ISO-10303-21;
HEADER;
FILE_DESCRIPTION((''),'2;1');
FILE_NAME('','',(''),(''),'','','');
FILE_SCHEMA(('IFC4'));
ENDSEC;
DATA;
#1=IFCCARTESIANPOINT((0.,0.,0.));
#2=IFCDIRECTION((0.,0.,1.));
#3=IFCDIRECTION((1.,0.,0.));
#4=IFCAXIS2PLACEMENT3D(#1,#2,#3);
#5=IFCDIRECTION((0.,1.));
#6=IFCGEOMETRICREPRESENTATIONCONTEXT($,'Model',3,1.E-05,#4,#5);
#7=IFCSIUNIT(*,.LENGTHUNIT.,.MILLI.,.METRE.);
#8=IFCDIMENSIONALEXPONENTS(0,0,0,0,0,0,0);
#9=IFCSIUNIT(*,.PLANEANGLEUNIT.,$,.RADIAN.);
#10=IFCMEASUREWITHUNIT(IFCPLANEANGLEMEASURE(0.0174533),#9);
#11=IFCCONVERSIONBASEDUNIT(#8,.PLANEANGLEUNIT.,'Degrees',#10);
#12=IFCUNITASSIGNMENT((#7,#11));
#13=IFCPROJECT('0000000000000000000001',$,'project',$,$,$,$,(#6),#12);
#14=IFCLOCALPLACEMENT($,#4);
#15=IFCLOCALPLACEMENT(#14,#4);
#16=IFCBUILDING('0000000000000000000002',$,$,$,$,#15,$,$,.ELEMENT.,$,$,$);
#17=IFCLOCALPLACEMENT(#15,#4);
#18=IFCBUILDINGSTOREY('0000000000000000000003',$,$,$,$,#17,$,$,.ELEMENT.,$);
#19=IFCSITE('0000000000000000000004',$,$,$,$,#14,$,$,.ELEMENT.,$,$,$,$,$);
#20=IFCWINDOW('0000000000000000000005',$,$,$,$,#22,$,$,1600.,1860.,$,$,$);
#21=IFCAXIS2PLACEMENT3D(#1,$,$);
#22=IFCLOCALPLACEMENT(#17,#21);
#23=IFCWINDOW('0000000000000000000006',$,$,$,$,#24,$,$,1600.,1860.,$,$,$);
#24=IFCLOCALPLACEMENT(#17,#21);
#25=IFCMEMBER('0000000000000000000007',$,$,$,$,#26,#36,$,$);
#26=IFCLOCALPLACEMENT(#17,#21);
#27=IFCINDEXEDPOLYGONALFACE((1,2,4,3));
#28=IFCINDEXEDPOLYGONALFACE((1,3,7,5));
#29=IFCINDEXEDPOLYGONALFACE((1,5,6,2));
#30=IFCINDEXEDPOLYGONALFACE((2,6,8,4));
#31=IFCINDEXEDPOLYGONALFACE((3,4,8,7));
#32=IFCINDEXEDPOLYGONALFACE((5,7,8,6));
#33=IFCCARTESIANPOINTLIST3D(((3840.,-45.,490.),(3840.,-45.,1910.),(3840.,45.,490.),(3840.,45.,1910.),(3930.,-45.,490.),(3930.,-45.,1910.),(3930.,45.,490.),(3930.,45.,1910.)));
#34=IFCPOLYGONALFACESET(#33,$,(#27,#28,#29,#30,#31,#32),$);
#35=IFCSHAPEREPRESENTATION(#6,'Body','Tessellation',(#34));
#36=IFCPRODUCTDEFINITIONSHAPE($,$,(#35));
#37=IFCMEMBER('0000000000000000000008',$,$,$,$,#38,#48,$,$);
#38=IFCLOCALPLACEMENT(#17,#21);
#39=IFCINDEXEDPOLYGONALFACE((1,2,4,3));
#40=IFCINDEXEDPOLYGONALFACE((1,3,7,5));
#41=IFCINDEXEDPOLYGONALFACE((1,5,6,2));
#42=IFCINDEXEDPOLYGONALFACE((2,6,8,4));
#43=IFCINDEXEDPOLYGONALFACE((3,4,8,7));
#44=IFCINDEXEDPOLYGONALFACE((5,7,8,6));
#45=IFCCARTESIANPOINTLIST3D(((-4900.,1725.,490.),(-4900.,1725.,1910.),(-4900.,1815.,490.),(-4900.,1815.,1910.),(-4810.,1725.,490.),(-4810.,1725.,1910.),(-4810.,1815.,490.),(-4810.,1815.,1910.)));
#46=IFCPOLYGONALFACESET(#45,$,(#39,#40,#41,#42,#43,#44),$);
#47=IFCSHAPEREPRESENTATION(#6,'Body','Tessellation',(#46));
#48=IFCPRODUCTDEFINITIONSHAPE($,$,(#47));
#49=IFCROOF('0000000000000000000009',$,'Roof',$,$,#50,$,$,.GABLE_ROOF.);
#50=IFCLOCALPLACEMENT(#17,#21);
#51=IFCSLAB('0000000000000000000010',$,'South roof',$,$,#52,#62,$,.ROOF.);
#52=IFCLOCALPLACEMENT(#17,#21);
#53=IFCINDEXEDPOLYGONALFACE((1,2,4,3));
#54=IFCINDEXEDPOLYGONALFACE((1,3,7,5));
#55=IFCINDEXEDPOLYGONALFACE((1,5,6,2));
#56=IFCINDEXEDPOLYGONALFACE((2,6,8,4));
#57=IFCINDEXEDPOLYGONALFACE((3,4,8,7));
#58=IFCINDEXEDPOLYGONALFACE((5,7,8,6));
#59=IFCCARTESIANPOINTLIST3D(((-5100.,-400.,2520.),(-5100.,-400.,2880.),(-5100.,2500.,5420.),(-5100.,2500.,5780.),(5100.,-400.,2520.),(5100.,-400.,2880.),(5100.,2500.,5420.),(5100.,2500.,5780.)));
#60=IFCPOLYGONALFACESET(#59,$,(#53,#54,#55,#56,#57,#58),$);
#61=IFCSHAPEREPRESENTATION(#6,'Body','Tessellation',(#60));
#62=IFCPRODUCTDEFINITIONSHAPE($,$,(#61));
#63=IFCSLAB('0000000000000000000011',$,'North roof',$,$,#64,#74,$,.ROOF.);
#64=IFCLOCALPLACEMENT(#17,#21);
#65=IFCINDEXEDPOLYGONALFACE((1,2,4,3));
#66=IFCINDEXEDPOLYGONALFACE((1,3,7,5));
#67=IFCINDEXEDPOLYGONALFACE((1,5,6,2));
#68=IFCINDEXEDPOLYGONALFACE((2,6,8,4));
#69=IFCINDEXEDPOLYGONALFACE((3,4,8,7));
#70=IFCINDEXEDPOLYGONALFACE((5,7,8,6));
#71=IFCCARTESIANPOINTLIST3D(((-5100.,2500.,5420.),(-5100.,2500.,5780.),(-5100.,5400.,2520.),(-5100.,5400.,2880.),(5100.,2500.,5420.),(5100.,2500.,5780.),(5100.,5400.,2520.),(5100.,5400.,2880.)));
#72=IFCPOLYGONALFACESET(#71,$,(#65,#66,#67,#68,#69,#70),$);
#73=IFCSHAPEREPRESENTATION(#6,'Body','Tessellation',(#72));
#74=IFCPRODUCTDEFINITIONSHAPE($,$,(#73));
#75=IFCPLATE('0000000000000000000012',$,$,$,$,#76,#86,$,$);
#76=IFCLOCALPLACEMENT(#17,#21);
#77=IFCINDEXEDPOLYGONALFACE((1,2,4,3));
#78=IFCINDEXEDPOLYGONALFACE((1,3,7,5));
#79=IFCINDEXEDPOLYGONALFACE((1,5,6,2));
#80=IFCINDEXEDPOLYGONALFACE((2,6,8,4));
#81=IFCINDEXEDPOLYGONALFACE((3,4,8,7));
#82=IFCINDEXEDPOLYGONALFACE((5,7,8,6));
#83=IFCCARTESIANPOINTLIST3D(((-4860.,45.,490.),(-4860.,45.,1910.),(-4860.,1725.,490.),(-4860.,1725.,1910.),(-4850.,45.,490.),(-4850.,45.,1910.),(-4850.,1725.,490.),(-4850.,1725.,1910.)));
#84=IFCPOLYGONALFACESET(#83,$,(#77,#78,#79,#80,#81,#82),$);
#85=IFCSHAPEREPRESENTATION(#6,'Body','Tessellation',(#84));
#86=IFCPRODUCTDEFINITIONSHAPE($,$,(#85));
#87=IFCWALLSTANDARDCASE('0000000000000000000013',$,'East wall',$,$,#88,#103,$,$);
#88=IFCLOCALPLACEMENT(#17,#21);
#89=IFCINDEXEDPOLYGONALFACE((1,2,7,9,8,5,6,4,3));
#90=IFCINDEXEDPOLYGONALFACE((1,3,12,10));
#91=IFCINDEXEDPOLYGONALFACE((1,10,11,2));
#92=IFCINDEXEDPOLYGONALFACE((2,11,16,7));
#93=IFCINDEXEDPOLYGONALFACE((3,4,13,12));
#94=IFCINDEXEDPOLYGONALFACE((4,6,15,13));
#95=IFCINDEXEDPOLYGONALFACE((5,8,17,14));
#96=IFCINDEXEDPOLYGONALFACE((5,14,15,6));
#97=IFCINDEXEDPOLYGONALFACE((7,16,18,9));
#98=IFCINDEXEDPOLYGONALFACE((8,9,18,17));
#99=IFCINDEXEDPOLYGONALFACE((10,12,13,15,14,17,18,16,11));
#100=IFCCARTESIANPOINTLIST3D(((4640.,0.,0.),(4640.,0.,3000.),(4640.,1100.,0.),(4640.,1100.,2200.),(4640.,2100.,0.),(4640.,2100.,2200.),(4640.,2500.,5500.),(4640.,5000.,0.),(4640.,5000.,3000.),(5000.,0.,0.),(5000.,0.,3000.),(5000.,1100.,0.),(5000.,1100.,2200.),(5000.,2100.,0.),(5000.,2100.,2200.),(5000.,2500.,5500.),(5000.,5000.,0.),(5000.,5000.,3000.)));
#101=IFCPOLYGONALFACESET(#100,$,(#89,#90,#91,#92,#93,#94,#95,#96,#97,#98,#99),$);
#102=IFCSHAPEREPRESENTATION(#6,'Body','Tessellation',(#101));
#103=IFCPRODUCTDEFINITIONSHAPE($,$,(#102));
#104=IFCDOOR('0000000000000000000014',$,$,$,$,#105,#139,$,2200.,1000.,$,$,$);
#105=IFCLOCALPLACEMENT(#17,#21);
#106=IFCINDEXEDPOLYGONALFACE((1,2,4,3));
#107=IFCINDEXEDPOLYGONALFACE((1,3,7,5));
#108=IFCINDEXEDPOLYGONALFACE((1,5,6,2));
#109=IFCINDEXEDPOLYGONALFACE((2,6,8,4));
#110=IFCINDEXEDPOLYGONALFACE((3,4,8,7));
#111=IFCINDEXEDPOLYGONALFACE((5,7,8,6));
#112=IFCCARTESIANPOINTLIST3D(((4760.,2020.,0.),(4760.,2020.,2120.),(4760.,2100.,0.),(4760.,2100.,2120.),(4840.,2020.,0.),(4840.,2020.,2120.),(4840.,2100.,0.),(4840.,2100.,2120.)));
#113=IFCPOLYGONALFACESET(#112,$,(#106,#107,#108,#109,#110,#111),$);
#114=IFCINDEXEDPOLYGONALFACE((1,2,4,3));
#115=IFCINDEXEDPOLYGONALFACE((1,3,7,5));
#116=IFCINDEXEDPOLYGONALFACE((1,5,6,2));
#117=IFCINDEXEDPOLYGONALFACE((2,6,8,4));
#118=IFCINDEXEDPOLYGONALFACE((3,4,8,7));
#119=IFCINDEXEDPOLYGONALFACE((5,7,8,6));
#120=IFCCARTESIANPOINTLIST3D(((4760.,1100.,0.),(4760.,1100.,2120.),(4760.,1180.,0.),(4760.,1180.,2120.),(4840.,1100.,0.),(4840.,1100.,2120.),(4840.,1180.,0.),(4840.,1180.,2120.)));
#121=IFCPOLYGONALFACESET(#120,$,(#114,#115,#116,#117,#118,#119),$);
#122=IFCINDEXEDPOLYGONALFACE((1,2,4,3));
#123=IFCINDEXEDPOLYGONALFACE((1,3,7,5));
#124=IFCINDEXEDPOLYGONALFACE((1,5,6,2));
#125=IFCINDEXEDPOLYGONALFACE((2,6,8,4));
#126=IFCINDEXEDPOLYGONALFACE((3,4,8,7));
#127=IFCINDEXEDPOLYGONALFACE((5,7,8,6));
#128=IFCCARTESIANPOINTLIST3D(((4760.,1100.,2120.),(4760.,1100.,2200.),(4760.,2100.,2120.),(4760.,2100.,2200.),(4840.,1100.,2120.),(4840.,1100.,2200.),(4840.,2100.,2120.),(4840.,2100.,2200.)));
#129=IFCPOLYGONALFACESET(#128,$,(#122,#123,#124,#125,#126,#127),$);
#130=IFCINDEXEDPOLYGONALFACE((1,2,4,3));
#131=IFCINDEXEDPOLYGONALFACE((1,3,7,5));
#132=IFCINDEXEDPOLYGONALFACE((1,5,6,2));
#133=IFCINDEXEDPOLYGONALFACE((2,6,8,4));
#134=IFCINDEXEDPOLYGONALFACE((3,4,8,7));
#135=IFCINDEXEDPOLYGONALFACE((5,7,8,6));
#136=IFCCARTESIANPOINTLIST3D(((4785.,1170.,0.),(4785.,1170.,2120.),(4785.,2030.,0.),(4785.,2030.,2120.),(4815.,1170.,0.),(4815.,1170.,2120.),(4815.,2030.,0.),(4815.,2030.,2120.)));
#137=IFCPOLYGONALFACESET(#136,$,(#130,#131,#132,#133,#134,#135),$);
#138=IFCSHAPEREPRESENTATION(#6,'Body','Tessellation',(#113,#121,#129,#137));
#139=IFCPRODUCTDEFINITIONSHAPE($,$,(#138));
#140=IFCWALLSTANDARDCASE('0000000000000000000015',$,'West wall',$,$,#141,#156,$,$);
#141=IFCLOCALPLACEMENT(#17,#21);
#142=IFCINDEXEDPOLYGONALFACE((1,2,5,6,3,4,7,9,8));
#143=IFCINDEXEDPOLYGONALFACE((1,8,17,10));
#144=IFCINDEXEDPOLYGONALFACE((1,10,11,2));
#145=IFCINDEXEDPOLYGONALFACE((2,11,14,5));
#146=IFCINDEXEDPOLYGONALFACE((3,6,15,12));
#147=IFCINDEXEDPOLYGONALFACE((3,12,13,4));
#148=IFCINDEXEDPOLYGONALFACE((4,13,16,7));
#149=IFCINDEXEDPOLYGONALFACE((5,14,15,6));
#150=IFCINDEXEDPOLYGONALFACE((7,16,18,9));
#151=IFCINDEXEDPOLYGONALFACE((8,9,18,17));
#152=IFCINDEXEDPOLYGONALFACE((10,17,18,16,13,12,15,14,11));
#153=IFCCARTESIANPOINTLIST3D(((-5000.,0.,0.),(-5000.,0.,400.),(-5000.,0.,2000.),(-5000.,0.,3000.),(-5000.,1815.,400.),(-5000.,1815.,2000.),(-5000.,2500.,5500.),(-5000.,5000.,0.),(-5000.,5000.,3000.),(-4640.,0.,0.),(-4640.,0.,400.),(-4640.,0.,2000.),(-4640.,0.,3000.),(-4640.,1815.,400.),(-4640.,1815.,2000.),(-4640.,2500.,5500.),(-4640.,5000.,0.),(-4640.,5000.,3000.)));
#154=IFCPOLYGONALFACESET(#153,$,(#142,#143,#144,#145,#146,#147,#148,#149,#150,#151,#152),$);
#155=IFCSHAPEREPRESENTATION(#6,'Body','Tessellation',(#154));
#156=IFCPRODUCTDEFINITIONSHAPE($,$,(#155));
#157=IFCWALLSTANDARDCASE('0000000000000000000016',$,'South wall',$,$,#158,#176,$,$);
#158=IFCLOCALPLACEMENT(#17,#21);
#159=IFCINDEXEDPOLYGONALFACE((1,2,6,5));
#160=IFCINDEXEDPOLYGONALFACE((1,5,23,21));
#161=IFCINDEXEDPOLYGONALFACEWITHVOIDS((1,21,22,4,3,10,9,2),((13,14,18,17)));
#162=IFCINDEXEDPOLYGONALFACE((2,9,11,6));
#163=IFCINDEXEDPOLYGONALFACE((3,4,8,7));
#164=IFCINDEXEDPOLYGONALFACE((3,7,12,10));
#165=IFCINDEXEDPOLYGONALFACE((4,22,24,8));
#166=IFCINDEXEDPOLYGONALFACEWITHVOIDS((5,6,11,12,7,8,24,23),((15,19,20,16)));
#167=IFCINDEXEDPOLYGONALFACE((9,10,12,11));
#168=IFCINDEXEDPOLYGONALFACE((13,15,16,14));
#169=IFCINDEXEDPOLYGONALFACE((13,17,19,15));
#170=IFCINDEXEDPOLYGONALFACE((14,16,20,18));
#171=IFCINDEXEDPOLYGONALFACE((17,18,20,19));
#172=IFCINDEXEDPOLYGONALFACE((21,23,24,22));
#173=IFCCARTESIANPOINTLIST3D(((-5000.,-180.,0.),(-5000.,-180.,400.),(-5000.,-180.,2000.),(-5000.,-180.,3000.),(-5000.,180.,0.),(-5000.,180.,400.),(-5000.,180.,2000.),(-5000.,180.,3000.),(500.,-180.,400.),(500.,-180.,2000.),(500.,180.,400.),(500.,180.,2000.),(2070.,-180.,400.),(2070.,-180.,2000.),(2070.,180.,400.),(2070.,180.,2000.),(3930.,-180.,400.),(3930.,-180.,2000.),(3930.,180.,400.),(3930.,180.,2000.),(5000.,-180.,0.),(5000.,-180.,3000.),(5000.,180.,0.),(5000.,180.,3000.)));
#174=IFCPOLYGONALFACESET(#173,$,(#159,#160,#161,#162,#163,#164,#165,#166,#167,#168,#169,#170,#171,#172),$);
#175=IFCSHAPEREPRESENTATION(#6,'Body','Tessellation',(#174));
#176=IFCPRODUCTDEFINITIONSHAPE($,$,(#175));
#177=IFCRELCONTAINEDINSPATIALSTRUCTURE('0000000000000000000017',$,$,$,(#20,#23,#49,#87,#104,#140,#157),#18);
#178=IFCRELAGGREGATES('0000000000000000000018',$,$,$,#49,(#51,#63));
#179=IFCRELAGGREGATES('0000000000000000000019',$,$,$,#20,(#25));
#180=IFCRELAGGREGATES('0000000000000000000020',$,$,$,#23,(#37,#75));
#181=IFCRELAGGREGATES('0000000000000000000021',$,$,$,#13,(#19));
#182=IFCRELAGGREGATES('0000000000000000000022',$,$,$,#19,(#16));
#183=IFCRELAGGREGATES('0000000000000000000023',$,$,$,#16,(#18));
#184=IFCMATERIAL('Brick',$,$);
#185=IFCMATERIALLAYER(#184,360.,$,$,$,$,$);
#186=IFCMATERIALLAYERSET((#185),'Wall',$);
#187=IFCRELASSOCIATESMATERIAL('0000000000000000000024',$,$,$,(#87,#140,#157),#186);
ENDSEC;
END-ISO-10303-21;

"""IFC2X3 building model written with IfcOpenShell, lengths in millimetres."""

from ifc_helpers import new_model, entity, si_unit, converted_unit, direction, frame, origin_with_axes, place, context, project, spatial, polyline, outline, extrude, clip, halfspace, source, transform, mapped, material, layer, layer_set, layer_usage, element, fill, aggregate, save


model = new_model("IFC2X3")

# Units and contexts
model_context = context("Model", 3, precision=1e-05, world=origin_with_axes(), true_north=direction((0.0, 1.0)))
ifc_project = project(units=[si_unit("LENGTHUNIT", "METRE", prefix="MILLI"), converted_unit("PLANEANGLEUNIT", "Degrees", entity("IfcPlaneAngleMeasure", 0.0174533), si_unit("PLANEANGLEUNIT", "RADIAN"), dimensions=[0, 0, 0, 0, 0, 0, 0])], contexts=[model_context])

# Site, building, storey
site_placement = place(None, origin_with_axes())
site = spatial("IfcSite", under=ifc_project, at=site_placement, CompositionType="ELEMENT")
building_placement = place(site_placement, origin_with_axes())
building = spatial("IfcBuilding", under=site, at=building_placement, CompositionType="ELEMENT")
storey_placement = place(building_placement, origin_with_axes())
storey = spatial("IfcBuildingStorey", under=building, at=storey_placement, CompositionType="ELEMENT")

# Windows
window_1_placement = place(storey_placement, frame((2070.0, -45.0, 400.0), z_axis=(0.0, 0.0, 1.0), x_axis=(1.0, 0.0, 0.0)))
window_1 = element("IfcWindow", 1, at=window_1_placement, inside=storey, OverallHeight=1600.0, OverallWidth=1860.0)
window_2_placement = place(storey_placement, frame((-4810.0, -45.0, 400.0), z_axis=(0.0, 0.0, 1.0), x_axis=(0.0, 1.0, 0.0)))
window_2 = element("IfcWindow", 2, at=window_2_placement, inside=storey, OverallHeight=1600.0, OverallWidth=1860.0)

# Members
shared_shape_1 = source(origin_with_axes(), model_context, "Body", "SweptSolid", [
    extrude(outline(polyline([(-45.0, -45.0), (45.0, -45.0), (45.0, 45.0), (-45.0, 45.0), (-45.0, -45.0), (-45.0, -45.0)])), origin_with_axes(), (0.0, 0.0, 1.0), 1420.0),
])
member_1_placement = place(window_1_placement, frame((1815.0, 45.0, 90.0), z_axis=(0.0, 0.0, 1.0), x_axis=(1.0, 0.0, 0.0)))
member_1 = element("IfcMember", 3, at=member_1_placement, context=model_context, shape_type="MappedRepresentation", body=[
    mapped(shared_shape_1, transform((0.0, 0.0, 0.0))),
])
member_2_placement = place(window_2_placement, frame((1815.0, 45.0, 90.0), z_axis=(0.0, 0.0, 1.0), x_axis=(1.0, 0.0, 0.0)))
member_2 = element("IfcMember", 4, at=member_2_placement, context=model_context, shape_type="MappedRepresentation", body=[
    mapped(shared_shape_1, transform((0.0, 0.0, 0.0))),
])

# Roof, slabs
roof_placement = place(storey_placement, origin_with_axes())
roof = element("IfcRoof", 5, at=roof_placement, inside=storey, Name="Roof", ShapeType="GABLE_ROOF")
shared_shape_2 = source(origin_with_axes(), model_context, "Body", "SweptSolid", [
    extrude(outline(polyline([(-5100.0, -180.0), (5100.0, -180.0), (5100.0, 180.0), (-5100.0, 180.0), (-5100.0, -180.0), (-5100.0, -180.0)])), frame((0.0, 0.0, 0.0), z_axis=(0.0, 1.0, 0.0), x_axis=(1.0, 0.0, 0.0)), (0.0, -0.707107, 0.707107), 4101.2),
])
slab_1_placement = place(roof_placement, frame((0.0, -400.0, 2700.0), z_axis=(0.0, 0.0, 1.0), x_axis=(1.0, 0.0, 0.0)))
slab_1 = element("IfcSlab", 6, at=slab_1_placement, Name="South roof", PredefinedType="ROOF", context=model_context, shape_type="MappedRepresentation", body=[
    mapped(shared_shape_2, transform((0.0, 0.0, 0.0))),
])
slab_2_placement = place(roof_placement, frame((0.0, 5400.0, 2700.0), z_axis=(0.0, 0.0, 1.0), x_axis=(-1.0, 0.0, 0.0)))
slab_2 = element("IfcSlab", 7, at=slab_2_placement, Name="North roof", PredefinedType="ROOF", context=model_context, shape_type="MappedRepresentation", body=[
    mapped(shared_shape_2, transform((0.0, 0.0, 0.0))),
])
aggregate(roof, [slab_1, slab_2])

# Plate
aggregate(window_1, [member_1])
plate_1_placement = place(window_2_placement, frame((930.0, 45.0, 90.0), z_axis=(0.0, 0.0, 1.0), x_axis=(1.0, 0.0, 0.0)))
plate_1 = element("IfcPlate", 8, at=plate_1_placement, context=model_context, shape_type="SweptSolid", body=[
    extrude(outline(polyline([(-840.0, -5.0), (840.0, -5.0), (840.0, 5.0), (-840.0, 5.0), (-840.0, -5.0), (-840.0, -5.0)])), origin_with_axes(), (0.0, 0.0, 1.0), 1420.0),
])
aggregate(window_2, [member_2, plate_1])

# Wall, opening, door
ifc_material = material(Name="Brick")
ifc_layer = layer(ifc_material, 360.0)
ifc_layer_set = layer_set([ifc_layer], Name="Wall")
ifc_layer_usage = layer_usage(ifc_layer_set, "AXIS2", "POSITIVE", -180.0)
shared_shape_3 = source(origin_with_axes(), model_context, "Body", "Clipping", [
    clip(clip(extrude(outline(polyline([(-2500.0, -180.0), (2500.0, -180.0), (2500.0, 180.0), (-2500.0, 180.0), (-2500.0, -180.0), (-2500.0, -180.0)])), origin_with_axes(), (0.0, 0.0, 1.0), 6000.0), halfspace(frame((-2500.0, 0.0, 3000.0), z_axis=(-1.0, 0.0, 1.0), x_axis=(1.0, 0.0, 0.0)), False)), halfspace(frame((2500.0, 0.0, 3000.0), z_axis=(1.0, 0.0, 1.0), x_axis=(1.0, 0.0, 0.0)), False)),
])
wall_1_placement = place(storey_placement, frame((4820.0, 2500.0, 0.0), z_axis=(0.0, 0.0, 1.0), x_axis=(0.0, 1.0, 0.0)))
wall_1 = element("IfcWallStandardCase", 9, at=wall_1_placement, inside=storey, material=ifc_layer_usage, Name="East wall", context=model_context, shape_type="MappedRepresentation", body=[
    mapped(shared_shape_3, transform((0.0, 0.0, 0.0))),
])
opening_1_placement = place(storey_placement, frame((4820.0, 1600.0, 0.0), z_axis=(0.0, 0.0, 1.0), x_axis=(1.0, 0.0, 0.0)))
opening_1 = element("IfcOpeningElement", 10, at=opening_1_placement, cuts=wall_1, context=model_context, shape_type="SweptSolid", body=[
    extrude(outline(polyline([(-500.0, -500.0), (500.0, -500.0), (500.0, 500.0), (-500.0, 500.0), (-500.0, -500.0), (-500.0, -500.0)])), origin_with_axes(), (0.0, 0.0, 1.0), 2200.0),
])
door_placement = place(storey_placement, frame((4800.0, 1600.0, 0.0), z_axis=(0.0, 0.0, 1.0), x_axis=(0.0, 1.0, 0.0)))
door = element("IfcDoor", 11, at=door_placement, inside=storey, OverallHeight=2200.0, OverallWidth=1000.0, context=model_context, shape_type="SweptSolid", body=[
    extrude(outline(polyline([(-40.0, -40.0), (40.0, -40.0), (40.0, 40.0), (-40.0, 40.0), (-40.0, -40.0), (-40.0, -40.0)])), frame((460.0, 0.0, 0.0), z_axis=(0.0, 0.0, 1.0), x_axis=(1.0, 0.0, 0.0)), (0.0, 0.0, 1.0), 2120.0),
    extrude(outline(polyline([(-40.0, -40.0), (40.0, -40.0), (40.0, 40.0), (-40.0, 40.0), (-40.0, -40.0), (-40.0, -40.0)])), frame((-460.0, 0.0, 0.0), z_axis=(0.0, 0.0, 1.0), x_axis=(1.0, 0.0, 0.0)), (0.0, 0.0, 1.0), 2120.0),
    extrude(outline(polyline([(-500.0, -40.0), (500.0, -40.0), (500.0, 40.0), (-500.0, 40.0), (-500.0, -40.0), (-500.0, -40.0)])), frame((0.0, 0.0, 2120.0), z_axis=(0.0, 0.0, 1.0), x_axis=(1.0, 0.0, 0.0)), (0.0, 0.0, 1.0), 80.0),
    extrude(outline(polyline([(-430.0, -15.0), (430.0, -15.0), (430.0, 15.0), (-430.0, 15.0), (-430.0, -15.0), (-430.0, -15.0)])), origin_with_axes(), (0.0, 0.0, 1.0), 2120.0),
])
fill(opening_1, door)

# Wall, opening
wall_2_placement = place(storey_placement, frame((-4820.0, 2500.0, 0.0), z_axis=(0.0, 0.0, 1.0), x_axis=(0.0, -1.0, 0.0)))
wall_2 = element("IfcWallStandardCase", 12, at=wall_2_placement, inside=storey, material=ifc_layer_usage, Name="West wall", context=model_context, shape_type="MappedRepresentation", body=[
    mapped(shared_shape_3, transform((0.0, 0.0, 0.0))),
])
opening_2_placement = place(wall_2_placement, frame((2500.0, 2320.0, 400.0), z_axis=(0.0, 0.0, 1.0), x_axis=(0.0, 1.0, 0.0)))
element("IfcOpeningElement", 13, at=opening_2_placement, cuts=wall_2, context=model_context, shape_type="SweptSolid", body=[
    extrude(outline(polyline([(-3000.0, -1815.0), (3000.0, -1815.0), (3000.0, 1815.0), (-3000.0, 1815.0), (-3000.0, -1815.0), (-3000.0, -1815.0)])), origin_with_axes(), (0.0, 0.0, 1.0), 1600.0),
])

# Wall, openings
wall_3_placement = place(storey_placement, origin_with_axes())
wall_3 = element("IfcWallStandardCase", 14, at=wall_3_placement, inside=storey, material=ifc_layer_usage, Name="South wall", context=model_context, shape_type="SweptSolid", body=[
    extrude(outline(polyline([(-5000.0, -180.0), (5000.0, -180.0), (5000.0, 180.0), (-5000.0, 180.0), (-5000.0, -180.0), (-5000.0, -180.0)])), origin_with_axes(), (0.0, 0.0, 1.0), 3000.0),
])
opening_3_placement = place(wall_3_placement, frame((-2500.0, 0.0, 400.0), z_axis=(0.0, 0.0, 1.0), x_axis=(1.0, 0.0, 0.0)))
element("IfcOpeningElement", 15, at=opening_3_placement, cuts=wall_3, context=model_context, shape_type="SweptSolid", body=[
    extrude(outline(polyline([(-3000.0, -1815.0), (3000.0, -1815.0), (3000.0, 1815.0), (-3000.0, 1815.0), (-3000.0, -1815.0), (-3000.0, -1815.0)])), origin_with_axes(), (0.0, 0.0, 1.0), 1600.0),
])
opening_4_placement = place(storey_placement, frame((3000.0, 0.0, 400.0), z_axis=(0.0, 0.0, 1.0), x_axis=(1.0, 0.0, 0.0)))
element("IfcOpeningElement", 16, at=opening_4_placement, cuts=wall_3, context=model_context, shape_type="SweptSolid", body=[
    extrude(outline(polyline([(-930.0, -1500.0), (930.0, -1500.0), (930.0, 1500.0), (-930.0, 1500.0), (-930.0, -1500.0), (-930.0, -1500.0)])), origin_with_axes(), (0.0, 0.0, 1.0), 1600.0),
])

save(model, "model.ifc")
